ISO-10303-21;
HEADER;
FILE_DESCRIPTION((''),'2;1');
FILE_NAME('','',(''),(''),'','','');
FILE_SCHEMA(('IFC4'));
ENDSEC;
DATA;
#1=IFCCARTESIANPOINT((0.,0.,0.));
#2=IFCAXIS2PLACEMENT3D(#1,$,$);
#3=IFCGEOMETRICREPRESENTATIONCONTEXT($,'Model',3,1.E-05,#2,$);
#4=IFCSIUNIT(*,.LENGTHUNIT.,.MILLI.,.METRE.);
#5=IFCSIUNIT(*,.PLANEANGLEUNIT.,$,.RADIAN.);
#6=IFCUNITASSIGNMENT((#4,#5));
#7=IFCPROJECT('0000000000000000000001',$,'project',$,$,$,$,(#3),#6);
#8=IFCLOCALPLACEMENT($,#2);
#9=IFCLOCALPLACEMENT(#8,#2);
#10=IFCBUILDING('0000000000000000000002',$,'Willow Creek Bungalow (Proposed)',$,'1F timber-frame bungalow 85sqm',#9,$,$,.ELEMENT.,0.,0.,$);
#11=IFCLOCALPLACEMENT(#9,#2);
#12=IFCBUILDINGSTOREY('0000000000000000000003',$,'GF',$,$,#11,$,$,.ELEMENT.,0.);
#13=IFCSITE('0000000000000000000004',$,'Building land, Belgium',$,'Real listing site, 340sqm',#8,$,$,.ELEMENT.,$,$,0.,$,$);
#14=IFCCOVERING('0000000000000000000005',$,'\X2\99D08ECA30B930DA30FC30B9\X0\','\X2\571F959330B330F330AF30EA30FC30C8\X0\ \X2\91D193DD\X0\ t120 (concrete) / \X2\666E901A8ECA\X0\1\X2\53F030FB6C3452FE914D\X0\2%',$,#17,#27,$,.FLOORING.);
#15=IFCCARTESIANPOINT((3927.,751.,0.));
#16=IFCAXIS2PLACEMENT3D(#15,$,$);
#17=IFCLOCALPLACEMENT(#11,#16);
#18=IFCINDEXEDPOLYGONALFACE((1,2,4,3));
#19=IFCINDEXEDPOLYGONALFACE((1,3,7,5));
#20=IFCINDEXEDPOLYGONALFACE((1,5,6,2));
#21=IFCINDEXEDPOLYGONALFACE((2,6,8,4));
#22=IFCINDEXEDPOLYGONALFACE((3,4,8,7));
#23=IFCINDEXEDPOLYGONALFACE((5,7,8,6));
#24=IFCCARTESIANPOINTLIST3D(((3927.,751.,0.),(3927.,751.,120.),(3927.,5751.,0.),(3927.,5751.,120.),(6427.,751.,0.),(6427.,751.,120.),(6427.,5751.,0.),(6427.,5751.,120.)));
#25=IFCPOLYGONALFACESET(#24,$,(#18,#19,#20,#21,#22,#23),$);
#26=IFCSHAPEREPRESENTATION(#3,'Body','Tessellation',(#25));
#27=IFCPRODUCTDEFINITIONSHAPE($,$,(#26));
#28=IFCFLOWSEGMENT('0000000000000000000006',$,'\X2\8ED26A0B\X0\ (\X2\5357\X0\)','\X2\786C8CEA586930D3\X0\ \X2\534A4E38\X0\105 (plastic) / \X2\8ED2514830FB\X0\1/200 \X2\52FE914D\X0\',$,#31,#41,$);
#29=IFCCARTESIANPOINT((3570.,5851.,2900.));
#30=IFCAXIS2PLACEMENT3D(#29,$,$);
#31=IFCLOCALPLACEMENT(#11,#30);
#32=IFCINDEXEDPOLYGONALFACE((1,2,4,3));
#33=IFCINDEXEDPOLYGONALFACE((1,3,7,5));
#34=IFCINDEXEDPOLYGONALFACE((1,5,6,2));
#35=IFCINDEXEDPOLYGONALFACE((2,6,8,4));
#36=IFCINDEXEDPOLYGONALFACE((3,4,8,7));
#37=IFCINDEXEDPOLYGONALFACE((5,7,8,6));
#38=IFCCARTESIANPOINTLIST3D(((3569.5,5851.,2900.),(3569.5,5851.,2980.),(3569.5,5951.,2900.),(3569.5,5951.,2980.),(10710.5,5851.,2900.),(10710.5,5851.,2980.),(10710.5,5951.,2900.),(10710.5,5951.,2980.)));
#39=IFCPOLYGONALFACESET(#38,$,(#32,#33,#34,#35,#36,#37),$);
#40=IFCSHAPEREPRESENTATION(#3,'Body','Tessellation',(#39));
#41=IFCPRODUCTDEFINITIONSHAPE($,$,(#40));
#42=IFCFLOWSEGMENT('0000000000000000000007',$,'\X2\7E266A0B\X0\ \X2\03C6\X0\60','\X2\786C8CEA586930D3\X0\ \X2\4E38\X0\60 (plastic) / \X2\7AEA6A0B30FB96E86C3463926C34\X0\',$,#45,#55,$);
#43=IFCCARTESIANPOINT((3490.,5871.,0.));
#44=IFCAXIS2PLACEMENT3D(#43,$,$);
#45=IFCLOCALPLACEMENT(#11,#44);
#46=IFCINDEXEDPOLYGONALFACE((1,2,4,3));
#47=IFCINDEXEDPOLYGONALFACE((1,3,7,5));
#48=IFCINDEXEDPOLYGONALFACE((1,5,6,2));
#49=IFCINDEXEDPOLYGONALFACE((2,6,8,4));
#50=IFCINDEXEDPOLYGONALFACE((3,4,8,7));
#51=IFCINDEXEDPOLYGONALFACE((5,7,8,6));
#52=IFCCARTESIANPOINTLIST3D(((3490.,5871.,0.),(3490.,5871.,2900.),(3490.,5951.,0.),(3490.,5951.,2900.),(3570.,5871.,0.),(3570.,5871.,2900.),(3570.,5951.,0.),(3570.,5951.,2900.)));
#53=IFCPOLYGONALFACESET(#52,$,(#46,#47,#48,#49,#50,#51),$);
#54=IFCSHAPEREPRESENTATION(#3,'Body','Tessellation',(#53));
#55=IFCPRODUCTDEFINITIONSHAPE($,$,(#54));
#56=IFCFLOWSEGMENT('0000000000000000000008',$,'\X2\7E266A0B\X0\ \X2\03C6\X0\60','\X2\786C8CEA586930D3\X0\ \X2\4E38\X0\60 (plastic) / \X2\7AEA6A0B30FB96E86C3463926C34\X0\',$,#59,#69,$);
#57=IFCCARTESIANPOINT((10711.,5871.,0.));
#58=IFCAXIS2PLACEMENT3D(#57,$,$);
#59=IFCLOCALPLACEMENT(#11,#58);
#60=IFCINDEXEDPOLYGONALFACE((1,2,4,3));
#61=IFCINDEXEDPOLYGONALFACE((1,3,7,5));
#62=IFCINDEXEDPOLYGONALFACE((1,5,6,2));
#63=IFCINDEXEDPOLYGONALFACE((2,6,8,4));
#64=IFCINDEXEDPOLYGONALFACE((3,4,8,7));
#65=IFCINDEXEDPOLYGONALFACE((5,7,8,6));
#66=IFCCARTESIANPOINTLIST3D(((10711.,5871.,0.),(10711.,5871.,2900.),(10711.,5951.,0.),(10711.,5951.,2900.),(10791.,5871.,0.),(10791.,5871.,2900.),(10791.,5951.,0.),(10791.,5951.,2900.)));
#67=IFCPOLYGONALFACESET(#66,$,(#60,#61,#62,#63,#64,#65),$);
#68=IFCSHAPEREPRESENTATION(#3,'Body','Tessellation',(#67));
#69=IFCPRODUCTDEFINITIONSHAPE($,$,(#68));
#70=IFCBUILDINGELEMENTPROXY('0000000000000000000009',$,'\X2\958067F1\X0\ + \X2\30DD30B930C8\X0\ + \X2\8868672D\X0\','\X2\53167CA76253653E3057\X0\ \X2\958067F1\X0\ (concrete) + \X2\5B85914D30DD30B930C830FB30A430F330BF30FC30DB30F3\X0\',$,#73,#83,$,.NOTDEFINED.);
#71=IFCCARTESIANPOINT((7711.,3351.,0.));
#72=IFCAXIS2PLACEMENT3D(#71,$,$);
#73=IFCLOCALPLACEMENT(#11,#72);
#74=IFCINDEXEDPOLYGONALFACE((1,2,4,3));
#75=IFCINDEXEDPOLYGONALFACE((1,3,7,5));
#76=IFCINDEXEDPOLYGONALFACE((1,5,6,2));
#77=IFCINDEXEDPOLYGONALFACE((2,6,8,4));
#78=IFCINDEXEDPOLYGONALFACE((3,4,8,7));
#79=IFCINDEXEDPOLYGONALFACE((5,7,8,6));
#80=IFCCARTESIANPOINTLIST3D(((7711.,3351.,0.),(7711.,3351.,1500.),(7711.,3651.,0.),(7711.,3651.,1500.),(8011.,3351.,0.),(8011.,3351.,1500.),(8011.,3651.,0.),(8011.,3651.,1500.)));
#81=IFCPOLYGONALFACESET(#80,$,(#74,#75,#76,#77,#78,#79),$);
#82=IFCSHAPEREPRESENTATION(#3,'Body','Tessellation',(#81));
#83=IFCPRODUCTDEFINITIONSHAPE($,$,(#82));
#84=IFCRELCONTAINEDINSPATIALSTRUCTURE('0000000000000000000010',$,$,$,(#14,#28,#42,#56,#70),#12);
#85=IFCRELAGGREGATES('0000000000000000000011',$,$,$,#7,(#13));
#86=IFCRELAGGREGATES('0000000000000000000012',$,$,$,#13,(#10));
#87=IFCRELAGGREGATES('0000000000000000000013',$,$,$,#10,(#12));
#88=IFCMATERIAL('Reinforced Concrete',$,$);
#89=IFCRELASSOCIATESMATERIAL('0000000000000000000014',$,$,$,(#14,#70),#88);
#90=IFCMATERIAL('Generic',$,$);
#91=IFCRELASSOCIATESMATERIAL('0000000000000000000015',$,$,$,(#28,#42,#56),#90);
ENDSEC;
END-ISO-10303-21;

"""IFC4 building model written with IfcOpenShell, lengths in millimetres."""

from ifc_helpers import new_model, si_unit, frame, frame_2d, origin, place, context, project, spatial, rectangle, extrude, material, element, save


model = new_model("IFC4")

# Units and contexts
model_context = context("Model", 3, precision=1e-05, world=origin())
ifc_project = project(units=[si_unit("LENGTHUNIT", "METRE", prefix="MILLI"), si_unit("PLANEANGLEUNIT", "RADIAN")], contexts=[model_context])

# Site, building, storey
site_placement = place(None, origin())
site = spatial("IfcSite", under=ifc_project, at=site_placement, Name="Building land, Belgium", ObjectType="Real listing site, 340sqm", CompositionType="ELEMENT", RefElevation=0.0)
building_placement = place(site_placement, origin())
building = spatial("IfcBuilding", under=site, at=building_placement, Name="Willow Creek Bungalow (Proposed)", ObjectType="1F timber-frame bungalow 85sqm", CompositionType="ELEMENT", ElevationOfRefHeight=0.0, ElevationOfTerrain=0.0)
storey_placement = place(building_placement, origin())
storey = spatial("IfcBuildingStorey", under=building, at=storey_placement, Name="GF", CompositionType="ELEMENT", Elevation=0.0)

# Shared definitions
ifc_material_1 = material(Name="Reinforced Concrete")

# Covering
covering_1_placement = place(storey_placement, frame((3927.0, 751.0, 0.0)))
element("IfcCovering", 1, at=covering_1_placement, inside=storey, material=ifc_material_1, Name="駐車スペース", Description="土間コンクリート 金鏝 t120 (concrete) / 普通車1台・水勾配2%", PredefinedType="FLOORING", context=model_context, shape_type="SweptSolid", body=[
    extrude(rectangle(XDim=2500.0, YDim=5000.0, at=frame_2d((1250.0, 2500.0))), frame((3927.0, 751.0, 0.0)), (0.0, 0.0, 1.0), 120.0),
])

# Flow segments
ifc_material_2 = material(Name="Generic")
flow_segment_1_placement = place(storey_placement, frame((3570.0, 5851.0, 2900.0)))
element("IfcFlowSegment", 2, at=flow_segment_1_placement, inside=storey, material=ifc_material_2, Name="軒樋 (南)", Description="硬質塩ビ 半丸105 (plastic) / 軒先・1/200 勾配", context=model_context, shape_type="SweptSolid", body=[
    extrude(rectangle(XDim=7141.0, YDim=100.0, at=frame_2d((3570.0, 50.0))), frame((3570.0, 5851.0, 2900.0)), (0.0, 0.0, 1.0), 80.0),
])
flow_segment_2_placement = place(storey_placement, frame((3490.0, 5871.0, 0.0)))
element("IfcFlowSegment", 3, at=flow_segment_2_placement, inside=storey, material=ifc_material_2, Name="縦樋 φ60", Description="硬質塩ビ 丸60 (plastic) / 竪樋・雨水排水", context=model_context, shape_type="SweptSolid", body=[
    extrude(rectangle(XDim=80.0, YDim=80.0, at=frame_2d((40.0, 40.0))), frame((3490.0, 5871.0, 0.0)), (0.0, 0.0, 1.0), 2900.0),
])
flow_segment_3_placement = place(storey_placement, frame((10711.0, 5871.0, 0.0)))
element("IfcFlowSegment", 4, at=flow_segment_3_placement, inside=storey, material=ifc_material_2, Name="縦樋 φ60", Description="硬質塩ビ 丸60 (plastic) / 竪樋・雨水排水", context=model_context, shape_type="SweptSolid", body=[
    extrude(rectangle(XDim=80.0, YDim=80.0, at=frame_2d((40.0, 40.0))), frame((10711.0, 5871.0, 0.0)), (0.0, 0.0, 1.0), 2900.0),
])

# Building element proxy
proxy_placement = place(storey_placement, frame((7711.0, 3351.0, 0.0)))
element("IfcBuildingElementProxy", 5, at=proxy_placement, inside=storey, material=ifc_material_1, Name="門柱 + ポスト + 表札", Description="化粧打放し 門柱 (concrete) + 宅配ポスト・インターホン", PredefinedType="NOTDEFINED", context=model_context, shape_type="SweptSolid", body=[
    extrude(rectangle(XDim=300.0, YDim=300.0, at=frame_2d((150.0, 150.0))), frame((7711.0, 3351.0, 0.0)), (0.0, 0.0, 1.0), 1500.0),
])

save(model, "model.ifc")
